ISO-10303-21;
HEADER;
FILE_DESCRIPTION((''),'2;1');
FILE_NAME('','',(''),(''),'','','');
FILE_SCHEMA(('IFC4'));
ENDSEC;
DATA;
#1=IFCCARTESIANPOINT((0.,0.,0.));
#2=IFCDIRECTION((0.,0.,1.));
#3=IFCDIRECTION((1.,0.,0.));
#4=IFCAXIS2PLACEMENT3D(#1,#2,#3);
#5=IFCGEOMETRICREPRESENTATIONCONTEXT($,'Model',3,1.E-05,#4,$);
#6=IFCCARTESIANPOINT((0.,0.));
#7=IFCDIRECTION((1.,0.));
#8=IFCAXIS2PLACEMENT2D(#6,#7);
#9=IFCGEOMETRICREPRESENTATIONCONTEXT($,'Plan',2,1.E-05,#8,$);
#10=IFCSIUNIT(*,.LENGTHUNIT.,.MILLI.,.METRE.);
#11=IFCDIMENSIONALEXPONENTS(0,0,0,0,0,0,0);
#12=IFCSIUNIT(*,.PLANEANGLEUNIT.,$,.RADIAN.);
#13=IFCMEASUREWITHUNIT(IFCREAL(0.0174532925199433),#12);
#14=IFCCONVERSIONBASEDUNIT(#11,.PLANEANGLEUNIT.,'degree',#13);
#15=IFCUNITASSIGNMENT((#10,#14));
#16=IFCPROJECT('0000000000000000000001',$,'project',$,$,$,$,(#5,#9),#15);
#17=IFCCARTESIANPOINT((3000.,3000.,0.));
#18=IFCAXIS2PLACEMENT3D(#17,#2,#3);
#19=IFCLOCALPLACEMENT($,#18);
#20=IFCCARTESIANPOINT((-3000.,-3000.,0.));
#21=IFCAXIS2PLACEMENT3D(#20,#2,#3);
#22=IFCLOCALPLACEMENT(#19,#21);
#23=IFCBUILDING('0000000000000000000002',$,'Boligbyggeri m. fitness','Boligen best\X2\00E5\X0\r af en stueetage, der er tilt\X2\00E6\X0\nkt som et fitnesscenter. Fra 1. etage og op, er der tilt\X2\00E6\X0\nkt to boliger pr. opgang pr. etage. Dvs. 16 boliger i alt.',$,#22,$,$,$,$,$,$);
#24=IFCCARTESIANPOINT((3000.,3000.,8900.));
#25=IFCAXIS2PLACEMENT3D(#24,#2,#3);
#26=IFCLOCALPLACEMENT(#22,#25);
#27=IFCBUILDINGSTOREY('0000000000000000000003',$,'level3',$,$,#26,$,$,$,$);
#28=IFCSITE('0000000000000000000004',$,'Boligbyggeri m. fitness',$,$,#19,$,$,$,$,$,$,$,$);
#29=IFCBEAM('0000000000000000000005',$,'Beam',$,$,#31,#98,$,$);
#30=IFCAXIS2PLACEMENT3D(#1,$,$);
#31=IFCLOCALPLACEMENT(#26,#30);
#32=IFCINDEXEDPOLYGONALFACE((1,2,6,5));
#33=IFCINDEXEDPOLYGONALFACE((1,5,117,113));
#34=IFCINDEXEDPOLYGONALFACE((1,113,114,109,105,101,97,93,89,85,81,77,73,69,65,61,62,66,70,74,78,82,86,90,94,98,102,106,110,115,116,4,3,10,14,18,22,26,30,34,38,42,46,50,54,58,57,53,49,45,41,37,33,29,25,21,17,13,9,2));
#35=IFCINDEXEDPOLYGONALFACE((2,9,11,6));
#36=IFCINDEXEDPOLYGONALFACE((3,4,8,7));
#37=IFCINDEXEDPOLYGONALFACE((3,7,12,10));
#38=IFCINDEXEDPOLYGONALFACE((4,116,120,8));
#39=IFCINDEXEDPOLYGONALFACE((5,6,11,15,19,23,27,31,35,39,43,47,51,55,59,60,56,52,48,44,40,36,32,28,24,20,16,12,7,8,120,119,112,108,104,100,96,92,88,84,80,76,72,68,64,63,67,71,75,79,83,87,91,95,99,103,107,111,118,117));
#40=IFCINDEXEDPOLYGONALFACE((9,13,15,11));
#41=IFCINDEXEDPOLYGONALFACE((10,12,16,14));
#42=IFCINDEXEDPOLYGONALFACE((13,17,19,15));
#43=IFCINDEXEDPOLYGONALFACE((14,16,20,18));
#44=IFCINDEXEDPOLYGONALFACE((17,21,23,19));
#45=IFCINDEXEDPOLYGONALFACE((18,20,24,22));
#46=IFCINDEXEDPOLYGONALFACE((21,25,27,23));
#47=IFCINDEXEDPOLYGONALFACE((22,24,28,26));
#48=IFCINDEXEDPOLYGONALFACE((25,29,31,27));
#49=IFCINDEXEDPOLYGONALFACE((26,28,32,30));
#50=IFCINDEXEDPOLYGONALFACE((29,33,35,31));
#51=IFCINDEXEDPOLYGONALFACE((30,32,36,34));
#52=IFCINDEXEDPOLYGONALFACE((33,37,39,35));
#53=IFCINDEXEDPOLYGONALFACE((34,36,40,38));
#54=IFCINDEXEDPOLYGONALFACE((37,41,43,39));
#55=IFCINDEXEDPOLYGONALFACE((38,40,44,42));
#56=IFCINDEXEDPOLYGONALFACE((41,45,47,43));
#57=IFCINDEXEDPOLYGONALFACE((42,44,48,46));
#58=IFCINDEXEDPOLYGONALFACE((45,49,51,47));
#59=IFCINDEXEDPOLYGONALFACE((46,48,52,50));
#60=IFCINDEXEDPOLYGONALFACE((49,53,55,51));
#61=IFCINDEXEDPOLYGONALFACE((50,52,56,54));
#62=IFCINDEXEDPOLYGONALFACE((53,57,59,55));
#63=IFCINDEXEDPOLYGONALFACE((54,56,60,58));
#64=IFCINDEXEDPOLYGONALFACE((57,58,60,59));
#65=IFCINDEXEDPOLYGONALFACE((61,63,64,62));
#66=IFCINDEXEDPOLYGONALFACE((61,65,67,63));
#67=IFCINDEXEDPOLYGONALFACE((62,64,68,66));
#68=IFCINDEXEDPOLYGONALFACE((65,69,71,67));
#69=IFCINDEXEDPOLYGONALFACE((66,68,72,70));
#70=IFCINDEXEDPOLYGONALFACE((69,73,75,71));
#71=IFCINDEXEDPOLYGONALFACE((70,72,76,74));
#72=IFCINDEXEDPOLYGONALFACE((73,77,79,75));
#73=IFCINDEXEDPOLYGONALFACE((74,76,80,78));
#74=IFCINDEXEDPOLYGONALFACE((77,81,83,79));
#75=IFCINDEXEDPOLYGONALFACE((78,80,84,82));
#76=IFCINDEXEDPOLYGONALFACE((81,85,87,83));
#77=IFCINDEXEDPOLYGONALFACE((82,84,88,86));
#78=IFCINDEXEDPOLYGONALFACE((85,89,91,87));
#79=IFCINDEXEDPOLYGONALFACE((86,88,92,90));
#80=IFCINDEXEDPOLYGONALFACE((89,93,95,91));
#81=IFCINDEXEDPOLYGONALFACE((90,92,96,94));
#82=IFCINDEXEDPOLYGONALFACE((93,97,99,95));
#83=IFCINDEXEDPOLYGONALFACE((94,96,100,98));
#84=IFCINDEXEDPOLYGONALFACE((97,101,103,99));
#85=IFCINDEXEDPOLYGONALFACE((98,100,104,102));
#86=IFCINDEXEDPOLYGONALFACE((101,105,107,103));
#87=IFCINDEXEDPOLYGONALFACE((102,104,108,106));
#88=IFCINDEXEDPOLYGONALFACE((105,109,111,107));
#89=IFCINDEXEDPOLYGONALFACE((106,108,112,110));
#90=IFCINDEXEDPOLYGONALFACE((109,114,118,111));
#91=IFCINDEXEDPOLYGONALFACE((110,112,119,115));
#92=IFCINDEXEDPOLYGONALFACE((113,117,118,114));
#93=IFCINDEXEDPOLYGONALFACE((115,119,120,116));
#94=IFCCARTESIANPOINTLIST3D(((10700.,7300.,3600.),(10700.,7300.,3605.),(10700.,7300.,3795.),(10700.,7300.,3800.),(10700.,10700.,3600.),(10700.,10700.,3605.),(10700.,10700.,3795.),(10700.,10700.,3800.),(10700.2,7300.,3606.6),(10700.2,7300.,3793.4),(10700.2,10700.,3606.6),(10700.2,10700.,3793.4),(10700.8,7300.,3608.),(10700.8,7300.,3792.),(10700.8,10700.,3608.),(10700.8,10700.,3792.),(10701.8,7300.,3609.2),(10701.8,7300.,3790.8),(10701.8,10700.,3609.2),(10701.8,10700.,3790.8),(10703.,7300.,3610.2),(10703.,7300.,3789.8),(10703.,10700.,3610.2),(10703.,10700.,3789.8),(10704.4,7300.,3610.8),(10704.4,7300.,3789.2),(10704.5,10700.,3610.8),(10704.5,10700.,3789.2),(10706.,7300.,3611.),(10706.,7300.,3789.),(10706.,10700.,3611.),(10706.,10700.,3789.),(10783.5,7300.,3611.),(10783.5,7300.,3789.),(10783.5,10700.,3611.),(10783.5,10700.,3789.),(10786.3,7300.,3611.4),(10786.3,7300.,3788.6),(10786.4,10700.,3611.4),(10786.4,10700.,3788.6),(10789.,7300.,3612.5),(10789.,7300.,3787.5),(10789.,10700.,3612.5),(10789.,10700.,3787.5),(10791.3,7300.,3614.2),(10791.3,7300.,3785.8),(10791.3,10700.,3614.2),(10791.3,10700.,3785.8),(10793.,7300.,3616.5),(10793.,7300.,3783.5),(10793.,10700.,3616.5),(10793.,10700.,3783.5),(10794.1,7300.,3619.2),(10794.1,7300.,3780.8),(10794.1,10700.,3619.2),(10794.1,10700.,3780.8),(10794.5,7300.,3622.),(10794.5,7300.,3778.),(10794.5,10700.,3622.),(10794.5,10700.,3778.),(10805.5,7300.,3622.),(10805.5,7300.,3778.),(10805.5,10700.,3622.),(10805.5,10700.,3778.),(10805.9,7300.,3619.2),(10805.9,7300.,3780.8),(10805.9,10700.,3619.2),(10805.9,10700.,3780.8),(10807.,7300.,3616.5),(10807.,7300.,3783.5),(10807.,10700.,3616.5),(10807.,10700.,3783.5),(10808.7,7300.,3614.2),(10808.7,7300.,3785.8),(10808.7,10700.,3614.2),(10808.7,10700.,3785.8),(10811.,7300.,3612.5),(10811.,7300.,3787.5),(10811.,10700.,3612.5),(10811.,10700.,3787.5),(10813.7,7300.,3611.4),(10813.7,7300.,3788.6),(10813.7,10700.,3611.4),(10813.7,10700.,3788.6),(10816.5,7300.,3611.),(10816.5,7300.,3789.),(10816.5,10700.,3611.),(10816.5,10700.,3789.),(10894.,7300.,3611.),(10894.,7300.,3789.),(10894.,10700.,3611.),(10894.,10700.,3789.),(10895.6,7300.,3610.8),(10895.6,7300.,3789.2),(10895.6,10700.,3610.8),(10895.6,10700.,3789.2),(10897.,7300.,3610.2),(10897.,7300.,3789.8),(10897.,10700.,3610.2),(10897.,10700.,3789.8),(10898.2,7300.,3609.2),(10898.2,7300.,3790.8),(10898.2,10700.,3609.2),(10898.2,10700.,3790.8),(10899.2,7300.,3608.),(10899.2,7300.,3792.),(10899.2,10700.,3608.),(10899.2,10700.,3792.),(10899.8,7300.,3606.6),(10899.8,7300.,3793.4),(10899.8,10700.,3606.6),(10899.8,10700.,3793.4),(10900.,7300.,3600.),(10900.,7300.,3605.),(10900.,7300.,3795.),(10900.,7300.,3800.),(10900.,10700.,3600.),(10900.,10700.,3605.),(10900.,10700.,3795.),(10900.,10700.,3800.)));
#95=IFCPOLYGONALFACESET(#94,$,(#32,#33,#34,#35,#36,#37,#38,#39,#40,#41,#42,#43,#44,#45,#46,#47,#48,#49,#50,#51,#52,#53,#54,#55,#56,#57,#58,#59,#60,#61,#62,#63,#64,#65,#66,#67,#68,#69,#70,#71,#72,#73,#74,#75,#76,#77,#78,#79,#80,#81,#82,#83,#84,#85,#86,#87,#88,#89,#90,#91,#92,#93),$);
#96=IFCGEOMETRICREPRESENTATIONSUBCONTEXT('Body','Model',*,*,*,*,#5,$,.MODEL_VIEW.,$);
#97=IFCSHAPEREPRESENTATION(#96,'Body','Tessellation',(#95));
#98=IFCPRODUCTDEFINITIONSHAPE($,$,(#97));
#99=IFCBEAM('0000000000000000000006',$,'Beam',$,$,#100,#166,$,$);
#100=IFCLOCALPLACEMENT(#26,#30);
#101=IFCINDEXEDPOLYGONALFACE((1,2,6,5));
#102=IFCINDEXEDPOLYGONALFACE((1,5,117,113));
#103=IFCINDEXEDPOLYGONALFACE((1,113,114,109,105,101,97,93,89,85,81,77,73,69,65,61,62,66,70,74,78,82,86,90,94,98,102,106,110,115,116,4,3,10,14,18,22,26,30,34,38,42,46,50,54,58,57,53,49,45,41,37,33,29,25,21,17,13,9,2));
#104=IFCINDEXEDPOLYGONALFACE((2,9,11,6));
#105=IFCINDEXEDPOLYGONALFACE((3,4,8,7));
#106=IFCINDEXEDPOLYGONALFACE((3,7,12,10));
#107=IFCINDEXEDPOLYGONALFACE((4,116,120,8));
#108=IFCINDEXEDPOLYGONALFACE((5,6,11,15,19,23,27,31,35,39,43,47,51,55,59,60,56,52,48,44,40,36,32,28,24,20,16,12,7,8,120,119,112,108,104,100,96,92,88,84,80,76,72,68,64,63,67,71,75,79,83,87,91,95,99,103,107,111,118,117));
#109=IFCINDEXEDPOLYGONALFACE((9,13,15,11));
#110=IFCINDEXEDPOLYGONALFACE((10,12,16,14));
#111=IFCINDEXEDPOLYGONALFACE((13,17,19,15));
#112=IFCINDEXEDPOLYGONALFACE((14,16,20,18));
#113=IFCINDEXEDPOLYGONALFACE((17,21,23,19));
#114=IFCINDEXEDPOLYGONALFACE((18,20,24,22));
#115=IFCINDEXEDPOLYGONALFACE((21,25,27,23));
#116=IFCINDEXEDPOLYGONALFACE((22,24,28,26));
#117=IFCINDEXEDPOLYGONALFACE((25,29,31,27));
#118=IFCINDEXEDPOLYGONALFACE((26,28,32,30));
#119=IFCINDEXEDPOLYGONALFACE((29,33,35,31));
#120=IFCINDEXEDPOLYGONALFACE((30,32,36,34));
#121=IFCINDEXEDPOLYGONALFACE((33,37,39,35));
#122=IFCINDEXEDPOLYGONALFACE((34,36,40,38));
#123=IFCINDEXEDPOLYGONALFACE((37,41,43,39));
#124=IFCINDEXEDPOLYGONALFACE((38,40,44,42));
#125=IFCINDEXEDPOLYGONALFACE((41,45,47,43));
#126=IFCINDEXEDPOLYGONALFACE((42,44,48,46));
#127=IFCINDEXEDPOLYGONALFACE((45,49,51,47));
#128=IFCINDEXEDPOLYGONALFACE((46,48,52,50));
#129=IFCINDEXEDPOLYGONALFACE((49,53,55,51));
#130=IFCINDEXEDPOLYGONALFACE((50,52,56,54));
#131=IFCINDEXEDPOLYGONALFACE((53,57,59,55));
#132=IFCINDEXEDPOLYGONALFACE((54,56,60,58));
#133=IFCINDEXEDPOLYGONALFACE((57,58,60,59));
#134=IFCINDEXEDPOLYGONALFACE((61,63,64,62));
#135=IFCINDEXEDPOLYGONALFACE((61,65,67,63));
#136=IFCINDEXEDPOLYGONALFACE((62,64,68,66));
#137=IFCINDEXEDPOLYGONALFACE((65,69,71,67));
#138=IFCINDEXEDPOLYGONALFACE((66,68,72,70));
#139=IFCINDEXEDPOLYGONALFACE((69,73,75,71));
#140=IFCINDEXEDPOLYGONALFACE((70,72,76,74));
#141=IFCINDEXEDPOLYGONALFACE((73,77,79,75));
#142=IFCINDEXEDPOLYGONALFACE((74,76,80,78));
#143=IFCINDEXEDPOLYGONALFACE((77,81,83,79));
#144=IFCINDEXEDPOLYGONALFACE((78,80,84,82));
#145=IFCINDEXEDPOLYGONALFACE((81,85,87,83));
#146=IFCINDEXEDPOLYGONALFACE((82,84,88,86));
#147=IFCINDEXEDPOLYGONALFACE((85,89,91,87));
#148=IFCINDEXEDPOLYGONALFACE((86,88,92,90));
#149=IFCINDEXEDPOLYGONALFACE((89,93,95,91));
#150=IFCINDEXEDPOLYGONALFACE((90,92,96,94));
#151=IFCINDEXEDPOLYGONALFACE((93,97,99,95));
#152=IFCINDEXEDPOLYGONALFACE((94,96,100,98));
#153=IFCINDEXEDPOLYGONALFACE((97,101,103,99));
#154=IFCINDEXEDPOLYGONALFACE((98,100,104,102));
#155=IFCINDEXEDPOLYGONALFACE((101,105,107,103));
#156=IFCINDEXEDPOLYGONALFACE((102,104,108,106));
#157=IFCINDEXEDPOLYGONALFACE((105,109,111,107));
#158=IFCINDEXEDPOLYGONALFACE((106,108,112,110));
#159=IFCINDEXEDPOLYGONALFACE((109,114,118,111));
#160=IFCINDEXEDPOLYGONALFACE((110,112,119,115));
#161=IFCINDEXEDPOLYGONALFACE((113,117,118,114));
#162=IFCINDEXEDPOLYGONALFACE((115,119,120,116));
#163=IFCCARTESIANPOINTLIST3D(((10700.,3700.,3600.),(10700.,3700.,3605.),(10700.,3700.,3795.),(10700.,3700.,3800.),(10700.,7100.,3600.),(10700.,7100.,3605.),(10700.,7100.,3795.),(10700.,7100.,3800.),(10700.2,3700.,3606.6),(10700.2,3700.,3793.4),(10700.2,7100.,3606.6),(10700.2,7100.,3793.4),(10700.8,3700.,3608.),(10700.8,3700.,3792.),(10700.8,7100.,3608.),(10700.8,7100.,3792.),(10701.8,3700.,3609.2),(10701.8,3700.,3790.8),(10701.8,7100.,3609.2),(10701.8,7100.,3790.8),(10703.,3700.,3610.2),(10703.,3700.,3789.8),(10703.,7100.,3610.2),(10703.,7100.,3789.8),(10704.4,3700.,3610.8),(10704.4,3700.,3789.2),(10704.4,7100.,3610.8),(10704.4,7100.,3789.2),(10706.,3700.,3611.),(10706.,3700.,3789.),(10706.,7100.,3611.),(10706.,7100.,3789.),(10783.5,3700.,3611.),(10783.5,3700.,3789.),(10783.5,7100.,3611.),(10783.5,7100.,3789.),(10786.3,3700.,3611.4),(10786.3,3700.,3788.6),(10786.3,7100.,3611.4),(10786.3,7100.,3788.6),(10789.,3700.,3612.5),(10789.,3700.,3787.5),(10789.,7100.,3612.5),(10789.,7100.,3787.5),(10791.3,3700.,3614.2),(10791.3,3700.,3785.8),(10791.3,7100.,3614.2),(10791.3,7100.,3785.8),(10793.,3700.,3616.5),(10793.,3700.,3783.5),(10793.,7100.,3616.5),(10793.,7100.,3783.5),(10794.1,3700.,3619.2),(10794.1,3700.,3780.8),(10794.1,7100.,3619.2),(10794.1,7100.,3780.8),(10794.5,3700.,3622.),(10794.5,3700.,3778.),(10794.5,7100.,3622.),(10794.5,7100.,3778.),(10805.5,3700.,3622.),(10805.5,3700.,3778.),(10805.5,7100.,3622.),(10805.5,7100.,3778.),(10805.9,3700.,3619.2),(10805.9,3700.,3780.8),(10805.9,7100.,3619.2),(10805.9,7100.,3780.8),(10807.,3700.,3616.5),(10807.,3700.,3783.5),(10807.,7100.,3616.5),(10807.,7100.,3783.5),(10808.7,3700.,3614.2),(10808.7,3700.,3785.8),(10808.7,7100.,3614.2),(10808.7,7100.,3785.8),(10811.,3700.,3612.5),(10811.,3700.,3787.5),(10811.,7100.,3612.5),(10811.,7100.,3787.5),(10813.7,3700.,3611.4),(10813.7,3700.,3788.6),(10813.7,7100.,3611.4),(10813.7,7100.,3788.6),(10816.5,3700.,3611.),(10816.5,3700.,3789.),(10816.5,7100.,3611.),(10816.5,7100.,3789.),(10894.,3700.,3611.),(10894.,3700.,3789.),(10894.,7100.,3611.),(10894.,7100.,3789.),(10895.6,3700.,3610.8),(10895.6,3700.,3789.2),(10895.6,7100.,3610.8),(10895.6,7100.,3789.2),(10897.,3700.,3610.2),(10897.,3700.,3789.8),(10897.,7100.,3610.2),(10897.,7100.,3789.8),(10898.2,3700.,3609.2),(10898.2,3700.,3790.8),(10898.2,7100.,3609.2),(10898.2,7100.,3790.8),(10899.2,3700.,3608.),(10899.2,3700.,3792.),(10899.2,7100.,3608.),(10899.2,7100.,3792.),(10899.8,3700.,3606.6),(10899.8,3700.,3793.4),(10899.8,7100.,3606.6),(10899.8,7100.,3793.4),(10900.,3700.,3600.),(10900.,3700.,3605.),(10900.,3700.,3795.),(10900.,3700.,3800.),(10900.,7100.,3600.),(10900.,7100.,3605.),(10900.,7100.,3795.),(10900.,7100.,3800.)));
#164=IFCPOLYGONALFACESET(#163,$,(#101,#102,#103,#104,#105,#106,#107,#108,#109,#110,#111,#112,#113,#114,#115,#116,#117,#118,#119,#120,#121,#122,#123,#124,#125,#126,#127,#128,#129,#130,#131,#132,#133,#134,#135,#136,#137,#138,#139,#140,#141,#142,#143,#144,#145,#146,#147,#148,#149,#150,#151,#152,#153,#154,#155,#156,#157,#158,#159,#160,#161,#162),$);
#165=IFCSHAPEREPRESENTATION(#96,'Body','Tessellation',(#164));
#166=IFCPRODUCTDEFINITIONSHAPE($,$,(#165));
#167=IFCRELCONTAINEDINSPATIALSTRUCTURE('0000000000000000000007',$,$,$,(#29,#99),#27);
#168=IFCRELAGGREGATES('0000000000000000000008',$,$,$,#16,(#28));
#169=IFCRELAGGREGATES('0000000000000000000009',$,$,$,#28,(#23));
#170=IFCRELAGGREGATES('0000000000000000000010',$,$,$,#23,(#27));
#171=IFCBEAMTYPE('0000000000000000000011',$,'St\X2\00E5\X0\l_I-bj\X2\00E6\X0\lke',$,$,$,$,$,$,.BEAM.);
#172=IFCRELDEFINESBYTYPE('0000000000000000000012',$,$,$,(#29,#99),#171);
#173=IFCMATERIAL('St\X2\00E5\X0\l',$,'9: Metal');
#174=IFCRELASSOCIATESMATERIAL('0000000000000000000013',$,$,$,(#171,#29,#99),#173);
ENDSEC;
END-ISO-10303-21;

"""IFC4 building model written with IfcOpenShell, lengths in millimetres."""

from ifc_helpers import new_model, entity, si_unit, converted_unit, frame, origin_with_axes, origin_2d_with_axis, place, context, subcontext, project, spatial, i_section, extrude, material, material_profile, profile_set, profile_usage, type_object, element, save


model = new_model("IFC4")

# Units and contexts
model_context = context("Model", 3, precision=1e-05, world=origin_with_axes())
plan_context = context("Plan", 2, precision=1e-05, world=origin_2d_with_axis())
body_context = subcontext(model_context, "Body", "Model", "MODEL_VIEW")
ifc_project = project(units=[si_unit("LENGTHUNIT", "METRE", prefix="MILLI"), converted_unit("PLANEANGLEUNIT", "degree", entity("IfcReal", 0.0174532925199433), si_unit("PLANEANGLEUNIT", "RADIAN"), dimensions=[0, 0, 0, 0, 0, 0, 0])], contexts=[model_context, plan_context])

# Site, building, storey
site_placement = place(None, frame((3000.0, 3000.0, 0.0), z_axis=(0.0, 0.0, 1.0), x_axis=(1.0, 0.0, 0.0)))
site = spatial("IfcSite", under=ifc_project, at=site_placement, Name="Boligbyggeri m. fitness")
building_placement = place(site_placement, frame((-3000.0, -3000.0, 0.0), z_axis=(0.0, 0.0, 1.0), x_axis=(1.0, 0.0, 0.0)))
building = spatial("IfcBuilding", under=site, at=building_placement, Name="Boligbyggeri m. fitness", Description="Boligen består af en stueetage, der er tiltænkt som et fitnesscenter. Fra 1. etage og op, er der tiltænkt to boliger pr. opgang pr. etage. Dvs. 16 boliger i alt.")
storey_placement = place(building_placement, frame((3000.0, 3000.0, 8900.0), z_axis=(0.0, 0.0, 1.0), x_axis=(1.0, 0.0, 0.0)))
storey = spatial("IfcBuildingStorey", under=building, at=storey_placement, Name="level3")

# Beams
ifc_material_1 = material(Name="Stål", Category="9: Metal")
ifc_material_profile_1 = material_profile(ifc_material_1, i_section(OverallWidth=200.0, OverallDepth=200.0, WebThickness=11.0, FlangeThickness=11.0, FilletRadius=11.0, FlangeEdgeRadius=6.0), Name="Stål", Category="9: Metal")
ifc_profile_set_1 = profile_set([ifc_material_profile_1], Name="NY_I-Profil")
beam_type = type_object("IfcBeamType", Name="Stål_I-bjælke", PredefinedType="BEAM", material=ifc_profile_set_1)
ifc_profile_usage_1 = profile_usage(ifc_profile_set_1, cardinal=9)
beam_1_placement = place(storey_placement, frame((10900.0, 7300.0, 3800.0), z_axis=(0.0, 1.0, 0.0), x_axis=(-1.0, 0.0, 0.0)))
element("IfcBeam", 1, at=beam_1_placement, inside=storey, type_object=beam_type, material=ifc_profile_usage_1, Name="Beam", context=body_context, shape_type="SweptSolid", body=[
    extrude(i_section(OverallWidth=200.0, OverallDepth=200.0, WebThickness=11.0, FlangeThickness=11.0, FilletRadius=11.0, FlangeEdgeRadius=6.0), frame((100.0, -100.0, 0.0), z_axis=(0.0, 0.0, 1.0), x_axis=(1.0, 0.0, 0.0)), (0.0, 0.0, 1.0), 3400.0),
])
ifc_profile_usage_2 = profile_usage(ifc_profile_set_1, cardinal=9)
beam_2_placement = place(storey_placement, frame((10900.0, 3700.0, 3800.0), z_axis=(0.0, 1.0, 0.0), x_axis=(-1.0, 0.0, 0.0)))
element("IfcBeam", 2, at=beam_2_placement, inside=storey, type_object=beam_type, material=ifc_profile_usage_2, Name="Beam", context=body_context, shape_type="SweptSolid", body=[
    extrude(i_section(OverallWidth=200.0, OverallDepth=200.0, WebThickness=11.0, FlangeThickness=11.0, FilletRadius=11.0, FlangeEdgeRadius=6.0), frame((100.0, -100.0, 0.0), z_axis=(0.0, 0.0, 1.0), x_axis=(1.0, 0.0, 0.0)), (0.0, 0.0, 1.0), 3400.0),
])

save(model, "model.ifc")
